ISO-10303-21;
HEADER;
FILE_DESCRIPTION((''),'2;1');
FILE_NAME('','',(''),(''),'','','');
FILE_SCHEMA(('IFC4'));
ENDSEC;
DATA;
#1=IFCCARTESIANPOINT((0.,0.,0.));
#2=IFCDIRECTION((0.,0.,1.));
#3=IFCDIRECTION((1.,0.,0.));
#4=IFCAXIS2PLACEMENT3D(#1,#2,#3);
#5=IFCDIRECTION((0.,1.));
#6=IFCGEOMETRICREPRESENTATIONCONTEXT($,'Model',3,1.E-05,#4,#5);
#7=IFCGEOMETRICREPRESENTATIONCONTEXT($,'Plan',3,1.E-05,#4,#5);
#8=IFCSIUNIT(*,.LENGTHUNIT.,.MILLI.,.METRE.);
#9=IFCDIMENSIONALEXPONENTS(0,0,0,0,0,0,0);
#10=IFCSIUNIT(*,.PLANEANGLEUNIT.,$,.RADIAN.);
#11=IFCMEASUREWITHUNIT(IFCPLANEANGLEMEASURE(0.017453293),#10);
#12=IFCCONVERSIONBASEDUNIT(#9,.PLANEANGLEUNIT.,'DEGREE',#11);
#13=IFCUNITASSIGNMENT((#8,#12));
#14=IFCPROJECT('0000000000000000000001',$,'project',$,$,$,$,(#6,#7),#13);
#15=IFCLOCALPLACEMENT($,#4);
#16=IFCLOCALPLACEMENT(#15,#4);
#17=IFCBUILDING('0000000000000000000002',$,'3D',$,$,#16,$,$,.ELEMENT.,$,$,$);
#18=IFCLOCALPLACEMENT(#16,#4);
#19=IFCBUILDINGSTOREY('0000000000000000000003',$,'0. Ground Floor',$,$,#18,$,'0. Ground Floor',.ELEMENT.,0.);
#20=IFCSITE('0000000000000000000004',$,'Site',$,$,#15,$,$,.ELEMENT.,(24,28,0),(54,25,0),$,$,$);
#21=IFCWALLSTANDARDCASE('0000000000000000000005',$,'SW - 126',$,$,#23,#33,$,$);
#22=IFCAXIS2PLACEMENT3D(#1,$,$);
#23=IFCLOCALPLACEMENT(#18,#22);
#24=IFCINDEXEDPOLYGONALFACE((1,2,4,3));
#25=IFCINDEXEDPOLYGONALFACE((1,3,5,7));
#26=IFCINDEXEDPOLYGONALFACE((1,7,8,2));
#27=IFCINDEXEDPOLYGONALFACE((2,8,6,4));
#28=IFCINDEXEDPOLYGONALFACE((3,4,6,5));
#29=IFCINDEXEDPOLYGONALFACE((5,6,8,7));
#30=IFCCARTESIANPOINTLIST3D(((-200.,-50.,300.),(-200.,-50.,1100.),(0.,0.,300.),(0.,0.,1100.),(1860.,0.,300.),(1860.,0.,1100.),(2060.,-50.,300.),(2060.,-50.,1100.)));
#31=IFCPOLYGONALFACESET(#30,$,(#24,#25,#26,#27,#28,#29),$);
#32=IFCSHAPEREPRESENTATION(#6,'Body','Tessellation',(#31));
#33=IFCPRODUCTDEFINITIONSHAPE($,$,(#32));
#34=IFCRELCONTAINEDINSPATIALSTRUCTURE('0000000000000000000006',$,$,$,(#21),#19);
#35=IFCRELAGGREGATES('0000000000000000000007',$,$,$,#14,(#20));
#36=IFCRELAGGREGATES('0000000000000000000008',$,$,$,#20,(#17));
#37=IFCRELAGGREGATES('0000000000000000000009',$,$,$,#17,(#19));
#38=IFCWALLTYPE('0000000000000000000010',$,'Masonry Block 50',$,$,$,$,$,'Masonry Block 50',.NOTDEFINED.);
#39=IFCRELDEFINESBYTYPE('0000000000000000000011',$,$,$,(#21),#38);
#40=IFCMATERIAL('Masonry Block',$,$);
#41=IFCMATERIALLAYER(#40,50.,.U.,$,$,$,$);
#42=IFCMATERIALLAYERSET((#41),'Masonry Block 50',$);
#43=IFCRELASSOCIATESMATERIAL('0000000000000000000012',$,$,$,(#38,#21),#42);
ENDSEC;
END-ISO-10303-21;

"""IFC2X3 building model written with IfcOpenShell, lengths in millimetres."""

from ifc_helpers import new_model, entity, si_unit, converted_unit, direction, frame, origin_with_axes, place, context, project, spatial, polyline, outline, extrude, material, layer, layer_set, layer_usage, type_object, element, save


model = new_model("IFC2X3")

# Units and contexts
model_context = context("Model", 3, precision=1e-05, world=origin_with_axes(), true_north=direction((0.0, 1.0)))
plan_context = context("Plan", 3, precision=1e-05, world=origin_with_axes(), true_north=direction((0.0, 1.0)))
ifc_project = project(units=[si_unit("LENGTHUNIT", "METRE", prefix="MILLI"), converted_unit("PLANEANGLEUNIT", "DEGREE", entity("IfcPlaneAngleMeasure", 0.017453293), si_unit("PLANEANGLEUNIT", "RADIAN"), dimensions=[0, 0, 0, 0, 0, 0, 0])], contexts=[model_context, plan_context])

# Site, building, storey
site_placement = place(None, origin_with_axes())
site = spatial("IfcSite", under=ifc_project, at=site_placement, Name="Site", CompositionType="ELEMENT", RefLatitude=(24, 28, 0), RefLongitude=(54, 25, 0))
building_placement = place(site_placement, origin_with_axes())
building = spatial("IfcBuilding", under=site, at=building_placement, Name="3D", CompositionType="ELEMENT")
storey_placement = place(building_placement, origin_with_axes())
storey = spatial("IfcBuildingStorey", under=building, at=storey_placement, Name="0. Ground Floor", LongName="0. Ground Floor", CompositionType="ELEMENT", Elevation=0.0)

# Shared definitions
ifc_material_1 = material(Name="Masonry Block")

# Wall
ifc_layer_1 = layer(ifc_material_1, 50.0, ventilated="UNKNOWN")
ifc_layer_set_1 = layer_set([ifc_layer_1], Name="Masonry Block 50")
ifc_layer_usage_1 = layer_usage(ifc_layer_set_1, "AXIS2", "POSITIVE", 0.0)
wall_type_1 = type_object("IfcWallType", Name="Masonry Block 50", ElementType="Masonry Block 50", PredefinedType="NOTDEFINED", material=ifc_layer_set_1)
wall_1_placement = place(storey_placement, frame((0.0, -50.0, 300.0), z_axis=(0.0, 0.0, 1.0), x_axis=(1.0, 0.0, 0.0)))
element("IfcWallStandardCase", 1, at=wall_1_placement, inside=storey, type_object=wall_type_1, material=ifc_layer_usage_1, Name="SW - 126", context=model_context, shape_type="SweptSolid", body=[
    extrude(outline(polyline([(-200.0, 0.0), (2060.0, 0.0), (1860.0, 50.0), (0.0, 50.0), (-200.0, 0.0)])), origin_with_axes(), (0.0, 0.0, 1.0), 800.0),
])

save(model, "model.ifc")
